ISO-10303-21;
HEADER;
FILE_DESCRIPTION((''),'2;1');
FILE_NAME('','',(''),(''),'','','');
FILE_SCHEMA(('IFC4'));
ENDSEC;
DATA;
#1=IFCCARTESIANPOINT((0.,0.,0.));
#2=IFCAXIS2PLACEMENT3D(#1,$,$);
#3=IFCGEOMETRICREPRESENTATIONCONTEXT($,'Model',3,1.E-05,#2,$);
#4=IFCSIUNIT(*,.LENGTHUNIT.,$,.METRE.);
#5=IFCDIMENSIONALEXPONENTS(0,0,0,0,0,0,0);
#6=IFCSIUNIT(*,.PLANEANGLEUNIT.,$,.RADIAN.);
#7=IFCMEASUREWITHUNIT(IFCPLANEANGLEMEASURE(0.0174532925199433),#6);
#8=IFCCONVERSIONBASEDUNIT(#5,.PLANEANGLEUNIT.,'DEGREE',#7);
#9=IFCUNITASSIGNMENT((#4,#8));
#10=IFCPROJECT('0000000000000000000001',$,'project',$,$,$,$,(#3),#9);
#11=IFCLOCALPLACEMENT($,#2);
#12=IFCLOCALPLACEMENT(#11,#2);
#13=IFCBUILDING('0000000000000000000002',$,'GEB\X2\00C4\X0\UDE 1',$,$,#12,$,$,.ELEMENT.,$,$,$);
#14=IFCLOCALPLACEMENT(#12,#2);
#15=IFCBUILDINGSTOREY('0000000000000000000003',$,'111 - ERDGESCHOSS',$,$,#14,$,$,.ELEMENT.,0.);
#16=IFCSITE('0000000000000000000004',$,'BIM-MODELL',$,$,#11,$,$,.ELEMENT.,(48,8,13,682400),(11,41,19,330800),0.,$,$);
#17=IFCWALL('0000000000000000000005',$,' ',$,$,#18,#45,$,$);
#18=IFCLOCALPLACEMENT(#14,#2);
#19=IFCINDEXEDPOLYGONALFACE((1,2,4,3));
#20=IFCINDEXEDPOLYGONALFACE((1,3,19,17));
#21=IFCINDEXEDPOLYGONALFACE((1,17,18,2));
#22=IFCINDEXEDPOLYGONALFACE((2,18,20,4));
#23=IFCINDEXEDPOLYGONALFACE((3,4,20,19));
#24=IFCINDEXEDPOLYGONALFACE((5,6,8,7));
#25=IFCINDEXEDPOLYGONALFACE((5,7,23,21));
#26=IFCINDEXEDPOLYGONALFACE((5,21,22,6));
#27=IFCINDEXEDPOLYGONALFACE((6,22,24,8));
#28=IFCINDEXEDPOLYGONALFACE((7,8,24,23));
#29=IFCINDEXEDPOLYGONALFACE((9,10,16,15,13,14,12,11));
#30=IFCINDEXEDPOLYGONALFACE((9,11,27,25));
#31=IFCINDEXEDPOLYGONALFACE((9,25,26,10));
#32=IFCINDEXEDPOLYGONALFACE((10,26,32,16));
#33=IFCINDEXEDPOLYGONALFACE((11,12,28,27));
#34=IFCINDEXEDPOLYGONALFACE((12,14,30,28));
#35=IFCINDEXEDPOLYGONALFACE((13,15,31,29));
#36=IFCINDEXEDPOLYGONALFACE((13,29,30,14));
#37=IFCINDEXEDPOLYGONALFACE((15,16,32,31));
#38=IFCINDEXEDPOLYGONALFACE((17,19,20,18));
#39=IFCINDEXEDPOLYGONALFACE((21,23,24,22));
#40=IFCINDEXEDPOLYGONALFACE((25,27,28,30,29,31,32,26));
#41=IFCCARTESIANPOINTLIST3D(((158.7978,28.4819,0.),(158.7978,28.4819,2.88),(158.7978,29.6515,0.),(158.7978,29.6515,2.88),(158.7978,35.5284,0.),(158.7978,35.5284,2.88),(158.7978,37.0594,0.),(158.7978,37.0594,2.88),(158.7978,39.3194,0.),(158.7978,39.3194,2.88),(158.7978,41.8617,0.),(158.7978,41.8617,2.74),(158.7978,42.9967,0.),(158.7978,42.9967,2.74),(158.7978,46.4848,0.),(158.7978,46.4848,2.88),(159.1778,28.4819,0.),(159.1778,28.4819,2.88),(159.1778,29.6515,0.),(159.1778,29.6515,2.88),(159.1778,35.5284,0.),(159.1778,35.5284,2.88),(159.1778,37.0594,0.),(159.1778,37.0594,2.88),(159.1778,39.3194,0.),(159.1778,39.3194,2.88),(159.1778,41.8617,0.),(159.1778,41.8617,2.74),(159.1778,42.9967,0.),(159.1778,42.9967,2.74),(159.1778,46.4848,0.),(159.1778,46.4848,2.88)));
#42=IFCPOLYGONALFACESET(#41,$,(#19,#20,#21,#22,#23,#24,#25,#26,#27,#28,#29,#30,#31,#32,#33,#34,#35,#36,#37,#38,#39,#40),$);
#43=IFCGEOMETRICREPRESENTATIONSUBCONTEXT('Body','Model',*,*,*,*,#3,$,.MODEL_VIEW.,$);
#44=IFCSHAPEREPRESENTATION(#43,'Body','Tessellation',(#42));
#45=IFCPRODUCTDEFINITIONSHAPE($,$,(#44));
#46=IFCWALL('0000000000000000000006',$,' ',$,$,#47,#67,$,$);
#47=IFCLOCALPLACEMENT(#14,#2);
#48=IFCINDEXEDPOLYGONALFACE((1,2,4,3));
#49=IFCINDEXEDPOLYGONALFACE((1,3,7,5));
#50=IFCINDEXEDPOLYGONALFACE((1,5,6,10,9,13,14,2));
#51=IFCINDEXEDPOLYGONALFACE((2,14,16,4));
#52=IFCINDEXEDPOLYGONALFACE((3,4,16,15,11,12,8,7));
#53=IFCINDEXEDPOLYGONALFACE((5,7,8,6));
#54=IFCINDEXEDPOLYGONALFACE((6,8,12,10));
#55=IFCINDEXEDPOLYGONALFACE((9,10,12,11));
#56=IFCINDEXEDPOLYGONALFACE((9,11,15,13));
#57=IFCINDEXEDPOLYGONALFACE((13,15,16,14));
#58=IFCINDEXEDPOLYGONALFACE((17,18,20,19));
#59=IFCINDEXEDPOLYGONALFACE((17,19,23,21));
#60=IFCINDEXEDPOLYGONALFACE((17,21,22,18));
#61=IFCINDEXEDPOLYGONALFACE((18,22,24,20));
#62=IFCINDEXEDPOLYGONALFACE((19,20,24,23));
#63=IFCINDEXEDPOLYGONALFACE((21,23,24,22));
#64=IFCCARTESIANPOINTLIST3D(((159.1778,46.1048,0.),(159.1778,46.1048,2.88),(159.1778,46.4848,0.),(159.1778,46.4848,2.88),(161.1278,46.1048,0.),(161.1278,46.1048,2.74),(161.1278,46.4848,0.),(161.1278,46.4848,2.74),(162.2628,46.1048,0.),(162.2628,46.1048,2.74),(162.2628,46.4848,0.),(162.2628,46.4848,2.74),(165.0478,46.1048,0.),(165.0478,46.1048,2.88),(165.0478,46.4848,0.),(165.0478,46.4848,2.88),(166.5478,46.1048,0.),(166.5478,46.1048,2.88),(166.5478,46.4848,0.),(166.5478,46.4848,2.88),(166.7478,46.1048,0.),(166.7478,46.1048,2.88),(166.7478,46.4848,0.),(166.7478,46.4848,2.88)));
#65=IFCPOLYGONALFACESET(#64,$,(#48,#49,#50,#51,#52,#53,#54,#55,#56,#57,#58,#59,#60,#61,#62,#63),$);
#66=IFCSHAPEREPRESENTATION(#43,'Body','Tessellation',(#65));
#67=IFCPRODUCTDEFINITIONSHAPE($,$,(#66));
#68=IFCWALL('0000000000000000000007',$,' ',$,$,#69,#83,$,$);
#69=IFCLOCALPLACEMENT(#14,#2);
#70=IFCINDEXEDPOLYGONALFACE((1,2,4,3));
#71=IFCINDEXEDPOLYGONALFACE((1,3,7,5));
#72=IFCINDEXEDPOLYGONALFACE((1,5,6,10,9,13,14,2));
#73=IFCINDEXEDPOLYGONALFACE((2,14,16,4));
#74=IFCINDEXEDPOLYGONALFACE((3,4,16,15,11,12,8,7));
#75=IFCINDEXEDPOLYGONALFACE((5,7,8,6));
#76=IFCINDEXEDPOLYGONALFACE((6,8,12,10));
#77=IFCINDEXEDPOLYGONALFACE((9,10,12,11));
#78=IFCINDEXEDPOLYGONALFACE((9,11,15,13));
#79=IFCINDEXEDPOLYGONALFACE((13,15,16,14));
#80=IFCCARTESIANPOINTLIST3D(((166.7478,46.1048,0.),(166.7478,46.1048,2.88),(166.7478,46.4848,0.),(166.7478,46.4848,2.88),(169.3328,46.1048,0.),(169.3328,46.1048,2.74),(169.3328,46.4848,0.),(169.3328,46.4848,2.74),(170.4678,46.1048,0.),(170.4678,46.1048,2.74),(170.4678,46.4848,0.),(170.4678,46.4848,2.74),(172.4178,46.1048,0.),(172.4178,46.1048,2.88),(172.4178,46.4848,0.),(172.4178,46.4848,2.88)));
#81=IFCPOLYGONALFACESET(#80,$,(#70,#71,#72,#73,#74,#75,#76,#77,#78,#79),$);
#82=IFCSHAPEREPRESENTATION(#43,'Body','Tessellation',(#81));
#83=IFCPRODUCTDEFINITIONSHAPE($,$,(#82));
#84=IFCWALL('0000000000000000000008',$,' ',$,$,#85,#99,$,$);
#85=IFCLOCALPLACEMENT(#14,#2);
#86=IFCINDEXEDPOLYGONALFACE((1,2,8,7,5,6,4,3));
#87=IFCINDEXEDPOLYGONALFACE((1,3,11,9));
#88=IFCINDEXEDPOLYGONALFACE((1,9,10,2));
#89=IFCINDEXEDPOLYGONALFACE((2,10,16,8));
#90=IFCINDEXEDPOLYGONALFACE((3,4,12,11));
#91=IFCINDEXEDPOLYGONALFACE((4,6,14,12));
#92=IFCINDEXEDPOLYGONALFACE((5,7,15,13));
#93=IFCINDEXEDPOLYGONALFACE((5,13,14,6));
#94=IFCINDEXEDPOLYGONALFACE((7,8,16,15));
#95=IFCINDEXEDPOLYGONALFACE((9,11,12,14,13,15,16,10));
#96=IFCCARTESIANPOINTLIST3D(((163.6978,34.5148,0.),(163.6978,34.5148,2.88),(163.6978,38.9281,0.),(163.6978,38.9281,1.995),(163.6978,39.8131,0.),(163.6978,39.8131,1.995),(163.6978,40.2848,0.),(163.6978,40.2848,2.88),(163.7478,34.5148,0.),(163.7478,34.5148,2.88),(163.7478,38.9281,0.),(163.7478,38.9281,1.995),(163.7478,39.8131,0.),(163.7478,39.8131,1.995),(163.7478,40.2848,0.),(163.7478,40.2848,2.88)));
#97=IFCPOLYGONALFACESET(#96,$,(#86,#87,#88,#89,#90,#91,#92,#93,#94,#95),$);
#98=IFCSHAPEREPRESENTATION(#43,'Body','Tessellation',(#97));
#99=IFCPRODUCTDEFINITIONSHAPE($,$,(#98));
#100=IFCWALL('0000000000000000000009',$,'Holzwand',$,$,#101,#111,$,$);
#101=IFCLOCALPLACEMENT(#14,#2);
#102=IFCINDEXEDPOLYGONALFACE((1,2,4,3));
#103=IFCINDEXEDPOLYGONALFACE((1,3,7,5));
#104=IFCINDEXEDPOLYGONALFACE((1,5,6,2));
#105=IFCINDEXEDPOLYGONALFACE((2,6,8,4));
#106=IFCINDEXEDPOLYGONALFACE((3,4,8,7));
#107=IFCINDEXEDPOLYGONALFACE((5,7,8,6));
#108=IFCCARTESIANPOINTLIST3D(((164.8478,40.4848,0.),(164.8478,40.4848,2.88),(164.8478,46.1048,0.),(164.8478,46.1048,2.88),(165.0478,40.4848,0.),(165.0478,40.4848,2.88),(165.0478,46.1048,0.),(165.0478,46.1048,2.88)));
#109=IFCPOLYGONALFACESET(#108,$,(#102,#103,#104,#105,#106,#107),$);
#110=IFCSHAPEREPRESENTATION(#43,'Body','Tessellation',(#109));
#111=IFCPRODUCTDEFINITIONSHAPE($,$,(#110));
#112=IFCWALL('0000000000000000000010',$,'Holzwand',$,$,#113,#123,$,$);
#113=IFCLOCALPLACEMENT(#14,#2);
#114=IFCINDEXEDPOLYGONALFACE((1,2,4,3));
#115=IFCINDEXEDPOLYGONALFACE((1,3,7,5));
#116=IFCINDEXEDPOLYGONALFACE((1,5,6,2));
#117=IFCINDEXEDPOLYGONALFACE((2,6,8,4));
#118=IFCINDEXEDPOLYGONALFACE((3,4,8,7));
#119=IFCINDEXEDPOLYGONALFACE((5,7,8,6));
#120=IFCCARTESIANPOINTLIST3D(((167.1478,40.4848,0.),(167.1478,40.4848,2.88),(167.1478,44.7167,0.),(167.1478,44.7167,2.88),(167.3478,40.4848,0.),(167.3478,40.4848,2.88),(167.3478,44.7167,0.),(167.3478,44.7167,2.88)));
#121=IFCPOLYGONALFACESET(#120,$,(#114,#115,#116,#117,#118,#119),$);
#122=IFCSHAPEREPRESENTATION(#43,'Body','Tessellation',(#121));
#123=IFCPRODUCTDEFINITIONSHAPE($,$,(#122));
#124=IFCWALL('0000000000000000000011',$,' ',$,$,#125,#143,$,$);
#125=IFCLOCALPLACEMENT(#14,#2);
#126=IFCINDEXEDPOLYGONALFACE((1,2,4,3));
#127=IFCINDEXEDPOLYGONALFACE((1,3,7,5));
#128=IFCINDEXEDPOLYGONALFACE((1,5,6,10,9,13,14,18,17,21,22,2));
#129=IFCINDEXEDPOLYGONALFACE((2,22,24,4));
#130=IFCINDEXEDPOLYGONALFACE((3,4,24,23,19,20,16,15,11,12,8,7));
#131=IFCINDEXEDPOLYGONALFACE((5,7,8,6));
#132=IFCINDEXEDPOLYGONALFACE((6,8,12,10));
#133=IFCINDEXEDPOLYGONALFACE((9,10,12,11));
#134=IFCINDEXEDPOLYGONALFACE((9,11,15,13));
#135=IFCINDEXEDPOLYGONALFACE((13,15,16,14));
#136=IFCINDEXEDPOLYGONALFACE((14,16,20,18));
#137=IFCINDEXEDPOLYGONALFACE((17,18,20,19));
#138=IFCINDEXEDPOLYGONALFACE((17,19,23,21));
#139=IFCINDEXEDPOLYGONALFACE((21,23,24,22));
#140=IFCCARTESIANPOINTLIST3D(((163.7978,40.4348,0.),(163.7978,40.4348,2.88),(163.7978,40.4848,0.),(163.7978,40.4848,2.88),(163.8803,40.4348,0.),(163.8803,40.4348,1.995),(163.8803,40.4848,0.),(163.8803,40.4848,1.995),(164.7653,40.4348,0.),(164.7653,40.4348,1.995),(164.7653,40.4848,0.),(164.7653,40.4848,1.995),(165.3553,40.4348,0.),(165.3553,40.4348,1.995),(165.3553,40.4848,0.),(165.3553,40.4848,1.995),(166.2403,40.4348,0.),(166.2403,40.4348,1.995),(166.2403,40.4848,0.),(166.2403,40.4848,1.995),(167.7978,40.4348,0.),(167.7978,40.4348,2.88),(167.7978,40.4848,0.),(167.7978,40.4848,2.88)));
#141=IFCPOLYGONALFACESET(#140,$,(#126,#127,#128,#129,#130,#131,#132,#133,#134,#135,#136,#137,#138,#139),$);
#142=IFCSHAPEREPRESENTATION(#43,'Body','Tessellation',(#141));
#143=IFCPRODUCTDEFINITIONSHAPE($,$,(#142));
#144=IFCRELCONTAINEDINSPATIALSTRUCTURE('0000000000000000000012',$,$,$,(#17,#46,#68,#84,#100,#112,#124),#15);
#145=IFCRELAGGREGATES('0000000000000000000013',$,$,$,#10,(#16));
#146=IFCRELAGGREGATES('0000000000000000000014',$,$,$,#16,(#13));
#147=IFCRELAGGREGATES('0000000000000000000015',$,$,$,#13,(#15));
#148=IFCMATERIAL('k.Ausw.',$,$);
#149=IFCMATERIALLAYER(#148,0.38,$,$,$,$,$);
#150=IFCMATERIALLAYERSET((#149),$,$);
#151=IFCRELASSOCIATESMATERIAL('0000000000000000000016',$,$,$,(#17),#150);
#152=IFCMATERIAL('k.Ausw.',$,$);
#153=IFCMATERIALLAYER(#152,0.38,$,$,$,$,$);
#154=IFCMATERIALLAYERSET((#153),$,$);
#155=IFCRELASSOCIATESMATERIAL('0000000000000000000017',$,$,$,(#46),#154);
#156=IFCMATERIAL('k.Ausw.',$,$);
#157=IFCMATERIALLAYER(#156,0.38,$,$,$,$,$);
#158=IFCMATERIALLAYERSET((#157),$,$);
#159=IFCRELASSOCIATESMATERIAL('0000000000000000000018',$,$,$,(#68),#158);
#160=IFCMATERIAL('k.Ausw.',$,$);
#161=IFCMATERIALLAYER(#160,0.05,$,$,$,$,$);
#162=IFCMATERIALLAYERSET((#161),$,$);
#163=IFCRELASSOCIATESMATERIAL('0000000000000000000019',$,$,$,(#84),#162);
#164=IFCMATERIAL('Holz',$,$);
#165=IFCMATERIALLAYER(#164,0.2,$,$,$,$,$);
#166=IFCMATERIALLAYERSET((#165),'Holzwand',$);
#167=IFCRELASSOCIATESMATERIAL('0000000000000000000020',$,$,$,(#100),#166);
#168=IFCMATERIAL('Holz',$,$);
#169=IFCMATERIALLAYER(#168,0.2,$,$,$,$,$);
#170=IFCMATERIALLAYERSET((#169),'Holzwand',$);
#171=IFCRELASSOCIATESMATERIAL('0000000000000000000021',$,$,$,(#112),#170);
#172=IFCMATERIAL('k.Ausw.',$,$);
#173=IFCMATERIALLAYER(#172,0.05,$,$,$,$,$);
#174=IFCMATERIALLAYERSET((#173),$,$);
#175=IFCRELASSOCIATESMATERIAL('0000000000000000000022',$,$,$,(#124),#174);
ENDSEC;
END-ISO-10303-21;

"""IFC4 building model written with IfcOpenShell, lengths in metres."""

from ifc_helpers import new_model, entity, si_unit, converted_unit, frame, frame_2d, origin, origin_with_axes, place, context, subcontext, project, spatial, polyline, rectangle, outline, extrude, material, layer, layer_set, layer_usage, element, save


model = new_model("IFC4")

# Units and contexts
model_context = context("Model", 3, precision=1e-05, world=origin())
body_context = subcontext(model_context, "Body", "Model", "MODEL_VIEW")
ifc_project = project(units=[si_unit("LENGTHUNIT", "METRE"), converted_unit("PLANEANGLEUNIT", "DEGREE", entity("IfcPlaneAngleMeasure", 0.0174532925199433), si_unit("PLANEANGLEUNIT", "RADIAN"), dimensions=[0, 0, 0, 0, 0, 0, 0])], contexts=[model_context])

# Site, building, storey
site_placement = place(None, origin())
site = spatial("IfcSite", under=ifc_project, at=site_placement, Name="BIM-MODELL", CompositionType="ELEMENT", RefLatitude=(48, 8, 13, 682400), RefLongitude=(11, 41, 19, 330800), RefElevation=0.0)
building_placement = place(site_placement, origin())
building = spatial("IfcBuilding", under=site, at=building_placement, Name="GEBÄUDE 1", CompositionType="ELEMENT")
storey_placement = place(building_placement, origin())
storey = spatial("IfcBuildingStorey", under=building, at=storey_placement, Name="111 - ERDGESCHOSS", CompositionType="ELEMENT", Elevation=0.0)

# Walls, openings
ifc_material_1 = material(Name="k.Ausw.")
ifc_layer_1 = layer(ifc_material_1, 0.38)
ifc_layer_set_1 = layer_set([ifc_layer_1])
ifc_layer_usage_1 = layer_usage(ifc_layer_set_1, "AXIS2", "POSITIVE", 0.0)
wall_1_placement = place(storey_placement, frame((158.7978, 46.4848, 0.0), z_axis=(0.0, 0.0, 1.0), x_axis=(0.0, -1.0, 0.0)))
wall_1 = element("IfcWall", 1, at=wall_1_placement, inside=storey, material=ifc_layer_usage_1, Name=" ", context=body_context, shape_type="SweptSolid", body=[
    extrude(rectangle(XDim=18.0029, YDim=0.38, at=frame_2d((9.0014, 0.19), x_axis=(1.0, 0.0))), origin_with_axes(), (0.0, 0.0, 1.0), 2.88),
])
opening_1_placement = place(wall_1_placement, frame((15.6983, 0.0, 0.0), z_axis=(0.0, 1.0, 0.0), x_axis=(0.0, 0.0, 1.0)))
element("IfcOpeningElement", 2, at=opening_1_placement, cuts=wall_1, ObjectType="Opening", context=body_context, shape_type="SweptSolid", body=[
    extrude(outline(polyline([(0.0, 1.135), (2.88, 1.135), (2.88, 0.0), (0.0, 0.0), (0.0, 1.135)])), origin_with_axes(), (0.0, 0.0, 1.0), 0.38),
])
opening_2_placement = place(wall_1_placement, frame((10.9564, 0.0, 0.0), z_axis=(0.0, 1.0, 0.0), x_axis=(0.0, 0.0, 1.0)))
element("IfcOpeningElement", 3, at=opening_2_placement, cuts=wall_1, ObjectType="Opening", context=body_context, shape_type="SweptSolid", body=[
    extrude(outline(polyline([(0.0, 1.135), (2.88, 1.135), (2.88, 0.0), (0.0, 0.0), (0.0, 1.135)])), origin_with_axes(), (0.0, 0.0, 1.0), 0.38),
])
opening_3_placement = place(wall_1_placement, frame((12.0914, 0.0, 0.0), z_axis=(0.0, 1.0, 0.0), x_axis=(0.0, 0.0, 1.0)))
element("IfcOpeningElement", 4, at=opening_3_placement, cuts=wall_1, ObjectType="Opening", context=body_context, shape_type="SweptSolid", body=[
    extrude(outline(polyline([(0.0, 3.608), (2.88, 3.608), (2.88, 0.0), (0.0, 0.0), (0.0, 3.608)])), origin_with_axes(), (0.0, 0.0, 1.0), 0.38),
])
opening_4_placement = place(wall_1_placement, frame((3.4881, 0.0, 0.0), z_axis=(0.0, 1.0, 0.0), x_axis=(0.0, 0.0, 1.0)))
element("IfcOpeningElement", 5, at=opening_4_placement, cuts=wall_1, ObjectType="Opening", context=body_context, shape_type="SweptSolid", body=[
    extrude(outline(polyline([(0.0, 1.135), (2.74, 1.135), (2.74, 0.0), (0.0, 0.0), (0.0, 1.135)])), origin_with_axes(), (0.0, 0.0, 1.0), 0.38),
])
opening_5_placement = place(wall_1_placement, frame((7.1654, 0.0, 0.0), z_axis=(0.0, 1.0, 0.0), x_axis=(0.0, 0.0, 1.0)))
element("IfcOpeningElement", 6, at=opening_5_placement, cuts=wall_1, ObjectType="Opening", context=body_context, shape_type="SweptSolid", body=[
    extrude(outline(polyline([(0.0, 2.26), (2.88, 2.26), (2.88, 0.0), (0.0, 0.0), (0.0, 2.26)])), origin_with_axes(), (0.0, 0.0, 1.0), 0.38),
])
ifc_material_2 = material(Name="k.Ausw.")
ifc_layer_2 = layer(ifc_material_2, 0.38)
ifc_layer_set_2 = layer_set([ifc_layer_2])
ifc_layer_usage_2 = layer_usage(ifc_layer_set_2, "AXIS2", "POSITIVE", 0.0)
wall_2_placement = place(storey_placement, frame((166.7478, 46.4848, 0.0), z_axis=(0.0, 0.0, 1.0), x_axis=(-1.0, 0.0, 0.0)))
wall_2 = element("IfcWall", 7, at=wall_2_placement, inside=storey, material=ifc_layer_usage_2, Name=" ", context=body_context, shape_type="SweptSolid", body=[
    extrude(rectangle(XDim=7.57, YDim=0.38, at=frame_2d((3.785, 0.19), x_axis=(1.0, 0.0))), origin_with_axes(), (0.0, 0.0, 1.0), 2.88),
])
opening_6_placement = place(wall_2_placement, frame((0.2, 0.0, -0.15), z_axis=(0.0, 1.0, 0.0), x_axis=(0.0, 0.0, 1.0)))
element("IfcOpeningElement", 8, at=opening_6_placement, cuts=wall_2, ObjectType="Opening", context=body_context, shape_type="SweptSolid", body=[
    extrude(outline(polyline([(0.0, 1.5), (3.03, 1.5), (3.03, 0.0), (0.0, 0.0), (0.0, 1.5)])), origin_with_axes(), (0.0, 0.0, 1.0), 0.38),
])
opening_7_placement = place(wall_2_placement, frame((5.62, 0.38, 0.0), z_axis=(0.0, -1.0, 0.0), x_axis=(0.0, 0.0, 1.0)))
element("IfcOpeningElement", 9, at=opening_7_placement, cuts=wall_2, ObjectType="Opening", context=body_context, shape_type="SweptSolid", body=[
    extrude(outline(polyline([(0.0, 1.135), (2.74, 1.135), (2.74, 0.0), (0.0, 0.0), (0.0, 1.135)])), origin_with_axes(), (0.0, 0.0, 1.0), 0.38),
])

# Walls, openings
ifc_material_3 = material(Name="k.Ausw.")
ifc_layer_3 = layer(ifc_material_3, 0.38)
ifc_layer_set_3 = layer_set([ifc_layer_3])
ifc_layer_usage_3 = layer_usage(ifc_layer_set_3, "AXIS2", "POSITIVE", 0.0)
wall_3_placement = place(storey_placement, frame((172.4178, 46.4848, 0.0), z_axis=(0.0, 0.0, 1.0), x_axis=(-1.0, 0.0, 0.0)))
wall_3 = element("IfcWall", 10, at=wall_3_placement, inside=storey, material=ifc_layer_usage_3, Name=" ", context=body_context, shape_type="SweptSolid", body=[
    extrude(rectangle(XDim=5.67, YDim=0.38, at=frame_2d((2.835, 0.19), x_axis=(1.0, 0.0))), origin_with_axes(), (0.0, 0.0, 1.0), 2.88),
])
opening_8_placement = place(wall_3_placement, frame((3.085, 0.38, 0.0), z_axis=(0.0, -1.0, 0.0), x_axis=(0.0, 0.0, 1.0)))
element("IfcOpeningElement", 11, at=opening_8_placement, cuts=wall_3, ObjectType="Opening", context=body_context, shape_type="SweptSolid", body=[
    extrude(outline(polyline([(0.0, 1.135), (2.74, 1.135), (2.74, 0.0), (0.0, 0.0), (0.0, 1.135)])), origin_with_axes(), (0.0, 0.0, 1.0), 0.38),
])
ifc_material_4 = material(Name="k.Ausw.")
ifc_layer_4 = layer(ifc_material_4, 0.05)
ifc_layer_set_4 = layer_set([ifc_layer_4])
ifc_layer_usage_4 = layer_usage(ifc_layer_set_4, "AXIS2", "POSITIVE", 0.0)
wall_4_placement = place(storey_placement, frame((163.6978, 40.2848, 0.0), z_axis=(0.0, 0.0, 1.0), x_axis=(0.0, -1.0, 0.0)))
wall_4 = element("IfcWall", 12, at=wall_4_placement, inside=storey, material=ifc_layer_usage_4, Name=" ", context=body_context, shape_type="SweptSolid", body=[
    extrude(rectangle(XDim=5.77, YDim=0.05, at=frame_2d((2.885, 0.025), x_axis=(1.0, 0.0))), origin_with_axes(), (0.0, 0.0, 1.0), 2.88),
])
opening_9_placement = place(wall_4_placement, frame((0.4717, 0.0, -0.14), z_axis=(0.0, 1.0, 0.0), x_axis=(0.0, 0.0, 1.0)))
element("IfcOpeningElement", 13, at=opening_9_placement, cuts=wall_4, ObjectType="Opening", context=body_context, shape_type="SweptSolid", body=[
    extrude(outline(polyline([(0.0, 0.885), (2.135, 0.885), (2.135, 0.0), (0.0, 0.0), (0.0, 0.885)])), origin_with_axes(), (0.0, 0.0, 1.0), 0.05),
])

# Walls
ifc_material_5 = material(Name="Holz")
ifc_layer_5 = layer(ifc_material_5, 0.2)
ifc_layer_set_5 = layer_set([ifc_layer_5], Name="Holzwand")
ifc_layer_usage_5 = layer_usage(ifc_layer_set_5, "AXIS2", "POSITIVE", 0.0)
wall_5_placement = place(storey_placement, frame((164.8478, 46.1048, 0.0), z_axis=(0.0, 0.0, 1.0), x_axis=(0.0, -1.0, 0.0)))
element("IfcWall", 14, at=wall_5_placement, inside=storey, material=ifc_layer_usage_5, Name="Holzwand", context=body_context, shape_type="SweptSolid", body=[
    extrude(rectangle(XDim=5.62, YDim=0.2, at=frame_2d((2.81, 0.1), x_axis=(1.0, 0.0))), origin_with_axes(), (0.0, 0.0, 1.0), 2.88),
])
ifc_material_6 = material(Name="Holz")
ifc_layer_6 = layer(ifc_material_6, 0.2)
ifc_layer_set_6 = layer_set([ifc_layer_6], Name="Holzwand")
ifc_layer_usage_6 = layer_usage(ifc_layer_set_6, "AXIS2", "POSITIVE", 0.0)
wall_6_placement = place(storey_placement, frame((167.1478, 44.7167, 0.0), z_axis=(0.0, 0.0, 1.0), x_axis=(0.0, -1.0, 0.0)))
element("IfcWall", 15, at=wall_6_placement, inside=storey, material=ifc_layer_usage_6, Name="Holzwand", context=body_context, shape_type="SweptSolid", body=[
    extrude(rectangle(XDim=4.2319, YDim=0.2, at=frame_2d((2.1159, 0.1), x_axis=(1.0, 0.0))), origin_with_axes(), (0.0, 0.0, 1.0), 2.88),
])

# Wall, openings
ifc_material_7 = material(Name="k.Ausw.")
ifc_layer_7 = layer(ifc_material_7, 0.05)
ifc_layer_set_7 = layer_set([ifc_layer_7])
ifc_layer_usage_7 = layer_usage(ifc_layer_set_7, "AXIS2", "POSITIVE", 0.0)
wall_7_placement = place(storey_placement, frame((167.7978, 40.4848, 0.0), z_axis=(0.0, 0.0, 1.0), x_axis=(-1.0, 0.0, 0.0)))
wall_7 = element("IfcWall", 16, at=wall_7_placement, inside=storey, material=ifc_layer_usage_7, Name=" ", context=body_context, shape_type="SweptSolid", body=[
    extrude(rectangle(XDim=4.0, YDim=0.05, at=frame_2d((2.0, 0.025), x_axis=(1.0, 0.0))), origin_with_axes(), (0.0, 0.0, 1.0), 2.88),
])
opening_10_placement = place(wall_7_placement, frame((3.9175, 0.05, -0.14), z_axis=(0.0, -1.0, 0.0), x_axis=(0.0, 0.0, 1.0)))
element("IfcOpeningElement", 17, at=opening_10_placement, cuts=wall_7, ObjectType="Opening", context=body_context, shape_type="SweptSolid", body=[
    extrude(outline(polyline([(0.0, 0.885), (2.135, 0.885), (2.135, 0.0), (0.0, 0.0), (0.0, 0.885)])), origin_with_axes(), (0.0, 0.0, 1.0), 0.05),
])
opening_11_placement = place(wall_7_placement, frame((1.5575, 0.0, -0.14), z_axis=(0.0, 1.0, 0.0), x_axis=(0.0, 0.0, 1.0)))
element("IfcOpeningElement", 18, at=opening_11_placement, cuts=wall_7, ObjectType="Opening", context=body_context, shape_type="SweptSolid", body=[
    extrude(outline(polyline([(0.0, 0.885), (2.135, 0.885), (2.135, 0.0), (0.0, 0.0), (0.0, 0.885)])), origin_with_axes(), (0.0, 0.0, 1.0), 0.05),
])

save(model, "model.ifc")
